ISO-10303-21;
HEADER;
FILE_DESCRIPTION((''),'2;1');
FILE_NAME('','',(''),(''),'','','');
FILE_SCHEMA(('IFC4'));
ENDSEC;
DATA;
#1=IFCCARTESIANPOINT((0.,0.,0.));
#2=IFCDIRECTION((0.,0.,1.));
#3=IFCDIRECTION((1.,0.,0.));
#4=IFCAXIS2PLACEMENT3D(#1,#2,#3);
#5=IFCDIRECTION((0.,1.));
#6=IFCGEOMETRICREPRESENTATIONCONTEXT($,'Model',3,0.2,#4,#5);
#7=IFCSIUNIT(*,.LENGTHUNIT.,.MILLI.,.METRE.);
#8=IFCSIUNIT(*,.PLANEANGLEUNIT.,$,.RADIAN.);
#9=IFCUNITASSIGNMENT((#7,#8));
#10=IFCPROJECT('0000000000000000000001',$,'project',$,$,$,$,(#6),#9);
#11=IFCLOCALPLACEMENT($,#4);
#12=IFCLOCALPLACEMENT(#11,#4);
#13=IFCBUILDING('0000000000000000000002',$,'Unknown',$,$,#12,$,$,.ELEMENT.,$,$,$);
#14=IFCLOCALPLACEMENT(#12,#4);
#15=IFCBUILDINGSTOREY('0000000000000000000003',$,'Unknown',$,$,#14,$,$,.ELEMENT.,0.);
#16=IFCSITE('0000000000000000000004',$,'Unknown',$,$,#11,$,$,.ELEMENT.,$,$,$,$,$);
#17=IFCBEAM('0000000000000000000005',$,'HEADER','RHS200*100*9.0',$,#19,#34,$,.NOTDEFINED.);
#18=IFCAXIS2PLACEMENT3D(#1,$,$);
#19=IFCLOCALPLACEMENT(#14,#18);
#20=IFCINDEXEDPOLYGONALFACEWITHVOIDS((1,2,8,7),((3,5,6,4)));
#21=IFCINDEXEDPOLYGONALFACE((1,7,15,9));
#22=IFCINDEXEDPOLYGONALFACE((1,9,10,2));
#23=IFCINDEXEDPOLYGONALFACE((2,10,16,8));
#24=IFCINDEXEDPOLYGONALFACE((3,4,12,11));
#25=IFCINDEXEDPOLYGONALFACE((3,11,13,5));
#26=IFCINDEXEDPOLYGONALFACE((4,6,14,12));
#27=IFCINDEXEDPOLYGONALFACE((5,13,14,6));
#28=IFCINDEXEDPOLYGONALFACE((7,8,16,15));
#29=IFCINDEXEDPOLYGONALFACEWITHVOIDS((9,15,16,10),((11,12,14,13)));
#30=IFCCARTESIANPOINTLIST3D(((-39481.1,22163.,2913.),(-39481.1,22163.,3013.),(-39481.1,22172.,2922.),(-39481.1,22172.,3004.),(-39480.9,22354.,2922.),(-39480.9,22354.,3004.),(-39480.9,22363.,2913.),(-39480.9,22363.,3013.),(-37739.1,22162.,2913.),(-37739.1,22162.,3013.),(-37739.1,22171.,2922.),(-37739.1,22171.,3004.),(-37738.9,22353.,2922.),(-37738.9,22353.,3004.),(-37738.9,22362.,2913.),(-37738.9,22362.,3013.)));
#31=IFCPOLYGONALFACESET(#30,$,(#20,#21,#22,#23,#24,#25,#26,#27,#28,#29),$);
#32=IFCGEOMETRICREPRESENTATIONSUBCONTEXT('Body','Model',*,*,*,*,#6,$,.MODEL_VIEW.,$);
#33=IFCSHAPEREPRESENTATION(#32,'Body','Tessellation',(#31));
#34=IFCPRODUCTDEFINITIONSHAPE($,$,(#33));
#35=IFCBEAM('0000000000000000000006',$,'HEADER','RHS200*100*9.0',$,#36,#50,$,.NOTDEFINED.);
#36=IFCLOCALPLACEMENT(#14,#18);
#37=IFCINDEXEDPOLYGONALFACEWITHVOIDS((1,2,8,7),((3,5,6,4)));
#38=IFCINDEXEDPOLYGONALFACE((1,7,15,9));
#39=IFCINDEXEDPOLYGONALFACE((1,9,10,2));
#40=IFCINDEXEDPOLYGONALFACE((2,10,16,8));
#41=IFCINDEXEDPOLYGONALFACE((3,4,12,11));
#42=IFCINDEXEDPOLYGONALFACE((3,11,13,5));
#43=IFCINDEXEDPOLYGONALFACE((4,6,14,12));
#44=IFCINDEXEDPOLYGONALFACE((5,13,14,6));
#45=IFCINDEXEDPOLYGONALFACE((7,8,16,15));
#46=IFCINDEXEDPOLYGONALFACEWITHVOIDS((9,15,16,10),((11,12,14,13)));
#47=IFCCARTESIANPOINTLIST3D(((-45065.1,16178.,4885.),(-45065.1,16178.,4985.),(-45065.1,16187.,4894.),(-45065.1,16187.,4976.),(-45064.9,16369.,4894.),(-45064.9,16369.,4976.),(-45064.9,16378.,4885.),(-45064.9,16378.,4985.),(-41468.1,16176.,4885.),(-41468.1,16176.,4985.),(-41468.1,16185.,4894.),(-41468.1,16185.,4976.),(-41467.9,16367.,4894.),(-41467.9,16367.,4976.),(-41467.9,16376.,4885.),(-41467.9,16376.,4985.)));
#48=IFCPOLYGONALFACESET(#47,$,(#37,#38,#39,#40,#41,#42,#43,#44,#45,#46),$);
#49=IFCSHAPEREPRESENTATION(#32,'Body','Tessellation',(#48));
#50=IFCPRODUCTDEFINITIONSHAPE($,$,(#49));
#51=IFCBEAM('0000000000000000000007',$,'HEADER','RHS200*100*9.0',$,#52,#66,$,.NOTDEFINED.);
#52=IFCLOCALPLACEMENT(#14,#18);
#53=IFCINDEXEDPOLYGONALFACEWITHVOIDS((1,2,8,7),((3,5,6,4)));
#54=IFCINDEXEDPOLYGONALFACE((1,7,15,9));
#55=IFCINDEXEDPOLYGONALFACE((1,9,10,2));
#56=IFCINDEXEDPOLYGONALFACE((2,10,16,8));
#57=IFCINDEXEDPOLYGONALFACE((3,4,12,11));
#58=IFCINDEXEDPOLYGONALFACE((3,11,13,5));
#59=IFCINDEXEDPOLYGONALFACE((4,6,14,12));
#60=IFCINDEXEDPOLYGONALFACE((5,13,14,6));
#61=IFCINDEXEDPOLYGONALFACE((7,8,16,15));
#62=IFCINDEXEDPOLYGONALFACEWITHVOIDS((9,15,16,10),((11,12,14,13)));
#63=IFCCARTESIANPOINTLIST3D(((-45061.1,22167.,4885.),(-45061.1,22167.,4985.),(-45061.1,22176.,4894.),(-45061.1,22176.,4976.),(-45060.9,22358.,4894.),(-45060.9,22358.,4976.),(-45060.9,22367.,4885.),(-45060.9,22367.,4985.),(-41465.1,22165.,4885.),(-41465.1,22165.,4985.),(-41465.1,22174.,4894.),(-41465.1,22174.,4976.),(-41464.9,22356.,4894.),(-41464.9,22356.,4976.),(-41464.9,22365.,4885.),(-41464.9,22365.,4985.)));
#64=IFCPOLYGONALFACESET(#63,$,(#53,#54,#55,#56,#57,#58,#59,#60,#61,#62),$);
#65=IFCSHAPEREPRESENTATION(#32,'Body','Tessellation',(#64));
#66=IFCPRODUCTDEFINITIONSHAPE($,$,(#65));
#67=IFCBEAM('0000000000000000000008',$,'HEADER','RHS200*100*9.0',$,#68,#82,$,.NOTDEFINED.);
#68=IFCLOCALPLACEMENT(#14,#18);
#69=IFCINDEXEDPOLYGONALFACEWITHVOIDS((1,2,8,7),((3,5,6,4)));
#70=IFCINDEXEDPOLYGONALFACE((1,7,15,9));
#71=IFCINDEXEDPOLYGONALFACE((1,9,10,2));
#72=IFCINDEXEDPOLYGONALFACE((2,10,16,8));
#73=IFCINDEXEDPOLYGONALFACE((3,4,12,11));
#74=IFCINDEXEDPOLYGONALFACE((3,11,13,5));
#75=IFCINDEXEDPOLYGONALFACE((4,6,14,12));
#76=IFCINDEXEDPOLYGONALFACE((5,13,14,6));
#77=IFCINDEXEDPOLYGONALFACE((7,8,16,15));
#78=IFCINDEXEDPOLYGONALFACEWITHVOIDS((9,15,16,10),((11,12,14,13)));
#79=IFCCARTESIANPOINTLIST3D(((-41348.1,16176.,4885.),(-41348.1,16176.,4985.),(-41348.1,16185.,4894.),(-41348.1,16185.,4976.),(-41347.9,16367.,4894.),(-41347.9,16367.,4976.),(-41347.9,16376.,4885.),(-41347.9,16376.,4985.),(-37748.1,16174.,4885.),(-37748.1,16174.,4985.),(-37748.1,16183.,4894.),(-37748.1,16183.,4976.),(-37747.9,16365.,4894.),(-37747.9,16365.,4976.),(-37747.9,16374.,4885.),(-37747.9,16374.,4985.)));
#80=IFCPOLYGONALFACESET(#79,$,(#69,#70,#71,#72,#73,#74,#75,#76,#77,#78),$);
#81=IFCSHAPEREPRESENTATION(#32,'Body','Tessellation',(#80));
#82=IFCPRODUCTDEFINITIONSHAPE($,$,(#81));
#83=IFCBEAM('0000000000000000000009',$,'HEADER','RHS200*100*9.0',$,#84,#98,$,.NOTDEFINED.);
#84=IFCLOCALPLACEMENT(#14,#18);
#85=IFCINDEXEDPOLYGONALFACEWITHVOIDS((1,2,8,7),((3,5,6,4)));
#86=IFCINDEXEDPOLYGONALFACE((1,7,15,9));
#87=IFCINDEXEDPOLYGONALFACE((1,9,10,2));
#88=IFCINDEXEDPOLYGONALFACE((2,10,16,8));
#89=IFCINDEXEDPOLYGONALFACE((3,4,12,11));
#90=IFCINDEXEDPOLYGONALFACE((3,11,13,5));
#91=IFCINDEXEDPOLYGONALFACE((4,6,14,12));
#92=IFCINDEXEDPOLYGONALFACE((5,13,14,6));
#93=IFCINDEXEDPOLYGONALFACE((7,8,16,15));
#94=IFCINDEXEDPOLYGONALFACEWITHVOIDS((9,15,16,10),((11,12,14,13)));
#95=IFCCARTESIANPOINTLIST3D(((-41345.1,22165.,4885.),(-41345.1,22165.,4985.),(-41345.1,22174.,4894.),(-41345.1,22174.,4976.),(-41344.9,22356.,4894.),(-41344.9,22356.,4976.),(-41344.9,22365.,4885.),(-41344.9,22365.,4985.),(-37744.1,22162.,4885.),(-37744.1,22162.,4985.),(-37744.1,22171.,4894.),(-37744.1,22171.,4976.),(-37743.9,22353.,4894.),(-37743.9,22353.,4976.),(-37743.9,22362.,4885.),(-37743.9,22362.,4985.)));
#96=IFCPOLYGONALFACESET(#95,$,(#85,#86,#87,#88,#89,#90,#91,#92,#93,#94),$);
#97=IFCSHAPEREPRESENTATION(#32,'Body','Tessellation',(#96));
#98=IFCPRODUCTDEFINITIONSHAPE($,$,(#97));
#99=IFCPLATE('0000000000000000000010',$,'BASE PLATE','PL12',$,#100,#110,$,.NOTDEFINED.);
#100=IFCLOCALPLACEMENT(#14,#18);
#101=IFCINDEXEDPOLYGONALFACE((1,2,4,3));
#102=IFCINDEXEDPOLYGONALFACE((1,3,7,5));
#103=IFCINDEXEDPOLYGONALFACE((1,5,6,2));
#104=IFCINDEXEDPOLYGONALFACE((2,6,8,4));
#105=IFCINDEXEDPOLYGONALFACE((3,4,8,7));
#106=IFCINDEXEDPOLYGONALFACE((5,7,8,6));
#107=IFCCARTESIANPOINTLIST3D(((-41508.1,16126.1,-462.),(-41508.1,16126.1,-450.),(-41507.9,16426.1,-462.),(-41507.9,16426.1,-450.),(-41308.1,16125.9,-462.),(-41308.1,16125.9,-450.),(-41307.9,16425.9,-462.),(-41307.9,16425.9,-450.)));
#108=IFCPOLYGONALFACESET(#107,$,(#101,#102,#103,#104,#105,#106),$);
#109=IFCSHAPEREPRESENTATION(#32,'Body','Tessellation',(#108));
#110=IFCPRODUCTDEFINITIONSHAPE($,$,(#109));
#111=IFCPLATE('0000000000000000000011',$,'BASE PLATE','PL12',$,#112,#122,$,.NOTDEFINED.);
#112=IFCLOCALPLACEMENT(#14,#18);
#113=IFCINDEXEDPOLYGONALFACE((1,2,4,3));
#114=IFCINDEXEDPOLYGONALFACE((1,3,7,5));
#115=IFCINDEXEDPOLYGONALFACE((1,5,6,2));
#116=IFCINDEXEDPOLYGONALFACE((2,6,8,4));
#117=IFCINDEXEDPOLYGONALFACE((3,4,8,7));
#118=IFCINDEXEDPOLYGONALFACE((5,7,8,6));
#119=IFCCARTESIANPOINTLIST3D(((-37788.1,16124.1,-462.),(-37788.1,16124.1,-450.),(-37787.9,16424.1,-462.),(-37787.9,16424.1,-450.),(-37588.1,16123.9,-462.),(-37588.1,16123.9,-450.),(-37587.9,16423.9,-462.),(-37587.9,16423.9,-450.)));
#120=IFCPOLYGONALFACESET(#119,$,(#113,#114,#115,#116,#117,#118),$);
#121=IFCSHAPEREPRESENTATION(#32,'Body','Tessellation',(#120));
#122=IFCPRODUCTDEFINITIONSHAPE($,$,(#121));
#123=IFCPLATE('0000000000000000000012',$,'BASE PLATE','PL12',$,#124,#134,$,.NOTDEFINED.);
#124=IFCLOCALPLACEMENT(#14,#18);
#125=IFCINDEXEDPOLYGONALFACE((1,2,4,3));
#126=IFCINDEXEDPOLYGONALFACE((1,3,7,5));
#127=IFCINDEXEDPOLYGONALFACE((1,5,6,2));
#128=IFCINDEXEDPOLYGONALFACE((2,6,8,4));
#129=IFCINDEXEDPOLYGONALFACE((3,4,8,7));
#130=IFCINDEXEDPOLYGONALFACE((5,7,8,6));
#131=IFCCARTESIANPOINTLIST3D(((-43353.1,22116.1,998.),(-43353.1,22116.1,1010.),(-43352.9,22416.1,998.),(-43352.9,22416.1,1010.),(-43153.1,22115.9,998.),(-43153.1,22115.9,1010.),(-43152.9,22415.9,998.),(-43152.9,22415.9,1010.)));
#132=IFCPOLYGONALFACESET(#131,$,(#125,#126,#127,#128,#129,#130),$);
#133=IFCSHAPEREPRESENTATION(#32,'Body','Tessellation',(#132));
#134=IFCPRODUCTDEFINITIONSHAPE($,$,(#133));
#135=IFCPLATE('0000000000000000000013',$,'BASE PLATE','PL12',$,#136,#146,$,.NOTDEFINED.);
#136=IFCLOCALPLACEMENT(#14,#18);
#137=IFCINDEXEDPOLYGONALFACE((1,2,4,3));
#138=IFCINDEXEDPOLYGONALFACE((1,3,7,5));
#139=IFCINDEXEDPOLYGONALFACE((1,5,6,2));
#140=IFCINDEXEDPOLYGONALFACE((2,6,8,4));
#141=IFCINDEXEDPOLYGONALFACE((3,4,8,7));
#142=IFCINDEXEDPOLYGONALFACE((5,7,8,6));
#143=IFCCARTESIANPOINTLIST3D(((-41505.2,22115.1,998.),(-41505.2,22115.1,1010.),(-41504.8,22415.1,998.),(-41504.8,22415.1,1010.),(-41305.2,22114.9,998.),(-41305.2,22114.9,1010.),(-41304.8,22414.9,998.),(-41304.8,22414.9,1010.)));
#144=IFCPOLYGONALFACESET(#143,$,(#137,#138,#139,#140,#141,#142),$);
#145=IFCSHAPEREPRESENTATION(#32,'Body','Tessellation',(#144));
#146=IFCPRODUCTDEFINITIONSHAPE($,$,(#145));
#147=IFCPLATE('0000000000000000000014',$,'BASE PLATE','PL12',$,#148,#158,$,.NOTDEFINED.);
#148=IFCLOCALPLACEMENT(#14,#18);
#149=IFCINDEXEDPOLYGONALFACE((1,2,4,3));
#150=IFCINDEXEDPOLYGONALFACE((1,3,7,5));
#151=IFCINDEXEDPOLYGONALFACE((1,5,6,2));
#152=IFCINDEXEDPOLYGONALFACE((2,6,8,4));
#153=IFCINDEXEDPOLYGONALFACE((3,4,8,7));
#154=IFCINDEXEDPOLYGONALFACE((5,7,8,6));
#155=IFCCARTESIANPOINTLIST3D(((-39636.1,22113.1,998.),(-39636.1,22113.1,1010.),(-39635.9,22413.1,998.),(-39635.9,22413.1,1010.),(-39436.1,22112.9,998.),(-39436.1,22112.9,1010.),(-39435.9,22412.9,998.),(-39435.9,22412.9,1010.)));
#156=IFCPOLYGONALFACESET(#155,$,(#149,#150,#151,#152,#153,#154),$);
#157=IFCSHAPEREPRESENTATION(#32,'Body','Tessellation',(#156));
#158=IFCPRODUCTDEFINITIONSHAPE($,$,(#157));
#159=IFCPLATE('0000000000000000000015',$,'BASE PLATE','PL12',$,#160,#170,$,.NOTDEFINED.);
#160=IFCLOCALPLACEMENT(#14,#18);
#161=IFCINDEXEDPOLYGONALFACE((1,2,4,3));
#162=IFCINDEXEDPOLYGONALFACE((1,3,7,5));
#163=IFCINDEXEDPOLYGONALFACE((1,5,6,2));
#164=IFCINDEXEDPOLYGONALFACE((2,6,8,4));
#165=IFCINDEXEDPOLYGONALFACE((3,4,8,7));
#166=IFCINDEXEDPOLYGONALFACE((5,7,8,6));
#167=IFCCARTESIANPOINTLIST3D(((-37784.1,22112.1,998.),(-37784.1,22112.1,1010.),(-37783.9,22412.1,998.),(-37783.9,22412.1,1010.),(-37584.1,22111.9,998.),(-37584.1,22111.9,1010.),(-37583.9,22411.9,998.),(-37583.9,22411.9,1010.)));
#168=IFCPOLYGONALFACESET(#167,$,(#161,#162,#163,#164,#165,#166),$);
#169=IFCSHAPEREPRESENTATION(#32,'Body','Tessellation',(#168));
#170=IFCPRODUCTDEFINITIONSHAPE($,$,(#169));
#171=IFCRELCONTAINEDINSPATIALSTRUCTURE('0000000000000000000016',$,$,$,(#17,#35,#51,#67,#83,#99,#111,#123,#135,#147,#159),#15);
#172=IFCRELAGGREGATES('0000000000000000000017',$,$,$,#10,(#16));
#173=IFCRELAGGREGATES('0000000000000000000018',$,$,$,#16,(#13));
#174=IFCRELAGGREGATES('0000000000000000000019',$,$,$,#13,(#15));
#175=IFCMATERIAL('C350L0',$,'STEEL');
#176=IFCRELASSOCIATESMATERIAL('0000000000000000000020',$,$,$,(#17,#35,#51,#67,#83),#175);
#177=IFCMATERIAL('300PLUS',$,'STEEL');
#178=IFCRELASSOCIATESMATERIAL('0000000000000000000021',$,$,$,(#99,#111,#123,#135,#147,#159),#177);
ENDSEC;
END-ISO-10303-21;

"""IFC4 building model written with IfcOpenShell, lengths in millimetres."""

from ifc_helpers import new_model, si_unit, direction, frame, origin_with_axes, place, context, subcontext, project, spatial, line, indexed_curve, outline, extrude, material, element, save


model = new_model("IFC4")

# Units and contexts
model_context = context("Model", 3, precision=0.2, world=origin_with_axes(), true_north=direction((0.0, 1.0)))
body_context = subcontext(model_context, "Body", "Model", "MODEL_VIEW")
ifc_project = project(units=[si_unit("LENGTHUNIT", "METRE", prefix="MILLI"), si_unit("PLANEANGLEUNIT", "RADIAN")], contexts=[model_context])

# Site, building, storey
site_placement = place(None, origin_with_axes())
site = spatial("IfcSite", under=ifc_project, at=site_placement, Name="Unknown", CompositionType="ELEMENT")
building_placement = place(site_placement, origin_with_axes())
building = spatial("IfcBuilding", under=site, at=building_placement, Name="Unknown", CompositionType="ELEMENT")
storey_placement = place(building_placement, origin_with_axes())
storey = spatial("IfcBuildingStorey", under=building, at=storey_placement, Name="Unknown", CompositionType="ELEMENT", Elevation=0.0)

# Shared definitions
ifc_material_1 = material(Name="C350L0", Category="STEEL")

# Beams
beam_1_placement = place(storey_placement, frame((-37739.0, 22262.0, 2963.0), z_axis=(0.0, 0.0, 1.0), x_axis=(-1.0, 0.000574, 0.0)))
element("IfcBeam", 1, at=beam_1_placement, inside=storey, material=ifc_material_1, Name="HEADER", Description="RHS200*100*9.0", PredefinedType="NOTDEFINED", context=body_context, shape_type="SolidModel", body=[
    extrude(outline(indexed_curve([(-50.0, -100.0), (50.0, -100.0), (50.0, 100.0), (-50.0, 100.0)], segments=[line(1, 2, 3, 4, 1)]), holes=[indexed_curve([(-41.0, -91.0), (-41.0, 91.0), (41.0, 91.0), (41.0, -91.0)], segments=[line(1, 2, 3, 4, 1)])]), frame((0.0, 0.0, 0.0), z_axis=(-1.0, 0.0, 0.0), x_axis=(0.0, 0.0, 1.0)), (0.0, 0.0, -1.0), 1742.0),
])
beam_2_placement = place(storey_placement, frame((-41468.0, 16276.0, 4935.0), z_axis=(0.0, 0.0, 1.0), x_axis=(-1.0, 0.000556, 0.0)))
element("IfcBeam", 2, at=beam_2_placement, inside=storey, material=ifc_material_1, Name="HEADER", Description="RHS200*100*9.0", PredefinedType="NOTDEFINED", context=body_context, shape_type="SolidModel", body=[
    extrude(outline(indexed_curve([(-50.0, -100.0), (50.0, -100.0), (50.0, 100.0), (-50.0, 100.0)], segments=[line(1, 2, 3, 4, 1)]), holes=[indexed_curve([(-41.0, -91.0), (-41.0, 91.0), (41.0, 91.0), (41.0, -91.0)], segments=[line(1, 2, 3, 4, 1)])]), frame((0.0, 0.0, 0.0), z_axis=(-1.0, 0.0, 0.0), x_axis=(0.0, 0.0, 1.0)), (0.0, 0.0, -1.0), 3597.0),
])
beam_3_placement = place(storey_placement, frame((-41465.0, 22265.0, 4935.0), z_axis=(0.0, 0.0, 1.0), x_axis=(-1.0, 0.000556, 0.0)))
element("IfcBeam", 3, at=beam_3_placement, inside=storey, material=ifc_material_1, Name="HEADER", Description="RHS200*100*9.0", PredefinedType="NOTDEFINED", context=body_context, shape_type="SolidModel", body=[
    extrude(outline(indexed_curve([(-50.0, -100.0), (50.0, -100.0), (50.0, 100.0), (-50.0, 100.0)], segments=[line(1, 2, 3, 4, 1)]), holes=[indexed_curve([(-41.0, -91.0), (-41.0, 91.0), (41.0, 91.0), (41.0, -91.0)], segments=[line(1, 2, 3, 4, 1)])]), frame((0.0, 0.0, 0.0), z_axis=(-1.0, 0.0, 0.0), x_axis=(0.0, 0.0, 1.0)), (0.0, 0.0, -1.0), 3596.0),
])
beam_4_placement = place(storey_placement, frame((-37748.0, 16274.0, 4935.0), z_axis=(0.0, 0.0, 1.0), x_axis=(-1.0, 0.000556, 0.0)))
element("IfcBeam", 4, at=beam_4_placement, inside=storey, material=ifc_material_1, Name="HEADER", Description="RHS200*100*9.0", PredefinedType="NOTDEFINED", context=body_context, shape_type="SolidModel", body=[
    extrude(outline(indexed_curve([(-50.0, -100.0), (50.0, -100.0), (50.0, 100.0), (-50.0, 100.0)], segments=[line(1, 2, 3, 4, 1)]), holes=[indexed_curve([(-41.0, -91.0), (-41.0, 91.0), (41.0, 91.0), (41.0, -91.0)], segments=[line(1, 2, 3, 4, 1)])]), frame((0.0, 0.0, 0.0), z_axis=(-1.0, 0.0, 0.0), x_axis=(0.0, 0.0, 1.0)), (0.0, 0.0, -1.0), 3600.0),
])
beam_5_placement = place(storey_placement, frame((-37744.0, 22262.0, 4935.0), z_axis=(0.0, 0.0, 1.0), x_axis=(-1.0, 0.000833, 0.0)))
element("IfcBeam", 5, at=beam_5_placement, inside=storey, material=ifc_material_1, Name="HEADER", Description="RHS200*100*9.0", PredefinedType="NOTDEFINED", context=body_context, shape_type="SolidModel", body=[
    extrude(outline(indexed_curve([(-50.0, -100.0), (50.0, -100.0), (50.0, 100.0), (-50.0, 100.0)], segments=[line(1, 2, 3, 4, 1)]), holes=[indexed_curve([(-41.0, -91.0), (-41.0, 91.0), (41.0, 91.0), (41.0, -91.0)], segments=[line(1, 2, 3, 4, 1)])]), frame((0.0, 0.0, 0.0), z_axis=(-1.0, 0.0, 0.0), x_axis=(0.0, 0.0, 1.0)), (0.0, 0.0, -1.0), 3601.0),
])

# Plates
ifc_material_2 = material(Name="300PLUS", Category="STEEL")
for number, where, z_axis, x_axis, name in (
    (6, (-41507.9, 16426.1, -456.0), (0.0, 0.0, 1.0), (-0.000667, -1.0, 0.0), "BASE PLATE"),
    (7, (-37787.9, 16424.1, -456.0), (0.0, 0.0, 1.0), (-0.000667, -1.0, 0.0), "BASE PLATE"),
    (8, (-43352.9, 22416.1, 1004.0), (0.0, 0.0, 1.0), (-0.000667, -1.0, 0.0), "BASE PLATE"),
):
    element("IfcPlate", number, at=place(storey_placement, frame(where, z_axis=z_axis, x_axis=x_axis)), inside=storey, material=ifc_material_2, Name=name, Description="PL12", PredefinedType="NOTDEFINED", context=body_context, shape_type="SolidModel", body=[
        extrude(outline(indexed_curve([(0.0, 0.0), (300.0, 0.0), (300.1, 200.0), (0.1, 200.0)], segments=[line(1, 2, 3, 4, 1)])), frame((0.0, 0.0, 6.0), z_axis=(0.0, 0.0, 1.0), x_axis=(1.0, 0.0, 0.0)), (0.0, 0.0, -1.0), 12.0),
    ])
plate_placement = place(storey_placement, frame((-41504.8, 22415.1, 1004.0), z_axis=(0.0, 0.0, 1.0), x_axis=(-0.001333, -0.999999, 0.0)))
element("IfcPlate", 9, at=plate_placement, inside=storey, material=ifc_material_2, Name="BASE PLATE", Description="PL12", PredefinedType="NOTDEFINED", context=body_context, shape_type="SolidModel", body=[
    extrude(outline(indexed_curve([(0.0, 0.0), (300.0, 0.0), (299.9, 200.0), (-0.1, 200.0)], segments=[line(1, 2, 3, 4, 1)])), frame((0.0, 0.0, 6.0), z_axis=(0.0, 0.0, 1.0), x_axis=(1.0, 0.0, 0.0)), (0.0, 0.0, -1.0), 12.0),
])
for number, where, z_axis, x_axis, name in (
    (10, (-39635.9, 22413.1, 1004.0), (0.0, 0.0, 1.0), (-0.000667, -1.0, 0.0), "BASE PLATE"),
    (11, (-37783.9, 22412.1, 1004.0), (0.0, 0.0, 1.0), (-0.000667, -1.0, 0.0), "BASE PLATE"),
):
    element("IfcPlate", number, at=place(storey_placement, frame(where, z_axis=z_axis, x_axis=x_axis)), inside=storey, material=ifc_material_2, Name=name, Description="PL12", PredefinedType="NOTDEFINED", context=body_context, shape_type="SolidModel", body=[
        extrude(outline(indexed_curve([(0.0, 0.0), (300.0, 0.0), (300.1, 200.0), (0.1, 200.0)], segments=[line(1, 2, 3, 4, 1)])), frame((0.0, 0.0, 6.0), z_axis=(0.0, 0.0, 1.0), x_axis=(1.0, 0.0, 0.0)), (0.0, 0.0, -1.0), 12.0),
    ])

save(model, "model.ifc")
